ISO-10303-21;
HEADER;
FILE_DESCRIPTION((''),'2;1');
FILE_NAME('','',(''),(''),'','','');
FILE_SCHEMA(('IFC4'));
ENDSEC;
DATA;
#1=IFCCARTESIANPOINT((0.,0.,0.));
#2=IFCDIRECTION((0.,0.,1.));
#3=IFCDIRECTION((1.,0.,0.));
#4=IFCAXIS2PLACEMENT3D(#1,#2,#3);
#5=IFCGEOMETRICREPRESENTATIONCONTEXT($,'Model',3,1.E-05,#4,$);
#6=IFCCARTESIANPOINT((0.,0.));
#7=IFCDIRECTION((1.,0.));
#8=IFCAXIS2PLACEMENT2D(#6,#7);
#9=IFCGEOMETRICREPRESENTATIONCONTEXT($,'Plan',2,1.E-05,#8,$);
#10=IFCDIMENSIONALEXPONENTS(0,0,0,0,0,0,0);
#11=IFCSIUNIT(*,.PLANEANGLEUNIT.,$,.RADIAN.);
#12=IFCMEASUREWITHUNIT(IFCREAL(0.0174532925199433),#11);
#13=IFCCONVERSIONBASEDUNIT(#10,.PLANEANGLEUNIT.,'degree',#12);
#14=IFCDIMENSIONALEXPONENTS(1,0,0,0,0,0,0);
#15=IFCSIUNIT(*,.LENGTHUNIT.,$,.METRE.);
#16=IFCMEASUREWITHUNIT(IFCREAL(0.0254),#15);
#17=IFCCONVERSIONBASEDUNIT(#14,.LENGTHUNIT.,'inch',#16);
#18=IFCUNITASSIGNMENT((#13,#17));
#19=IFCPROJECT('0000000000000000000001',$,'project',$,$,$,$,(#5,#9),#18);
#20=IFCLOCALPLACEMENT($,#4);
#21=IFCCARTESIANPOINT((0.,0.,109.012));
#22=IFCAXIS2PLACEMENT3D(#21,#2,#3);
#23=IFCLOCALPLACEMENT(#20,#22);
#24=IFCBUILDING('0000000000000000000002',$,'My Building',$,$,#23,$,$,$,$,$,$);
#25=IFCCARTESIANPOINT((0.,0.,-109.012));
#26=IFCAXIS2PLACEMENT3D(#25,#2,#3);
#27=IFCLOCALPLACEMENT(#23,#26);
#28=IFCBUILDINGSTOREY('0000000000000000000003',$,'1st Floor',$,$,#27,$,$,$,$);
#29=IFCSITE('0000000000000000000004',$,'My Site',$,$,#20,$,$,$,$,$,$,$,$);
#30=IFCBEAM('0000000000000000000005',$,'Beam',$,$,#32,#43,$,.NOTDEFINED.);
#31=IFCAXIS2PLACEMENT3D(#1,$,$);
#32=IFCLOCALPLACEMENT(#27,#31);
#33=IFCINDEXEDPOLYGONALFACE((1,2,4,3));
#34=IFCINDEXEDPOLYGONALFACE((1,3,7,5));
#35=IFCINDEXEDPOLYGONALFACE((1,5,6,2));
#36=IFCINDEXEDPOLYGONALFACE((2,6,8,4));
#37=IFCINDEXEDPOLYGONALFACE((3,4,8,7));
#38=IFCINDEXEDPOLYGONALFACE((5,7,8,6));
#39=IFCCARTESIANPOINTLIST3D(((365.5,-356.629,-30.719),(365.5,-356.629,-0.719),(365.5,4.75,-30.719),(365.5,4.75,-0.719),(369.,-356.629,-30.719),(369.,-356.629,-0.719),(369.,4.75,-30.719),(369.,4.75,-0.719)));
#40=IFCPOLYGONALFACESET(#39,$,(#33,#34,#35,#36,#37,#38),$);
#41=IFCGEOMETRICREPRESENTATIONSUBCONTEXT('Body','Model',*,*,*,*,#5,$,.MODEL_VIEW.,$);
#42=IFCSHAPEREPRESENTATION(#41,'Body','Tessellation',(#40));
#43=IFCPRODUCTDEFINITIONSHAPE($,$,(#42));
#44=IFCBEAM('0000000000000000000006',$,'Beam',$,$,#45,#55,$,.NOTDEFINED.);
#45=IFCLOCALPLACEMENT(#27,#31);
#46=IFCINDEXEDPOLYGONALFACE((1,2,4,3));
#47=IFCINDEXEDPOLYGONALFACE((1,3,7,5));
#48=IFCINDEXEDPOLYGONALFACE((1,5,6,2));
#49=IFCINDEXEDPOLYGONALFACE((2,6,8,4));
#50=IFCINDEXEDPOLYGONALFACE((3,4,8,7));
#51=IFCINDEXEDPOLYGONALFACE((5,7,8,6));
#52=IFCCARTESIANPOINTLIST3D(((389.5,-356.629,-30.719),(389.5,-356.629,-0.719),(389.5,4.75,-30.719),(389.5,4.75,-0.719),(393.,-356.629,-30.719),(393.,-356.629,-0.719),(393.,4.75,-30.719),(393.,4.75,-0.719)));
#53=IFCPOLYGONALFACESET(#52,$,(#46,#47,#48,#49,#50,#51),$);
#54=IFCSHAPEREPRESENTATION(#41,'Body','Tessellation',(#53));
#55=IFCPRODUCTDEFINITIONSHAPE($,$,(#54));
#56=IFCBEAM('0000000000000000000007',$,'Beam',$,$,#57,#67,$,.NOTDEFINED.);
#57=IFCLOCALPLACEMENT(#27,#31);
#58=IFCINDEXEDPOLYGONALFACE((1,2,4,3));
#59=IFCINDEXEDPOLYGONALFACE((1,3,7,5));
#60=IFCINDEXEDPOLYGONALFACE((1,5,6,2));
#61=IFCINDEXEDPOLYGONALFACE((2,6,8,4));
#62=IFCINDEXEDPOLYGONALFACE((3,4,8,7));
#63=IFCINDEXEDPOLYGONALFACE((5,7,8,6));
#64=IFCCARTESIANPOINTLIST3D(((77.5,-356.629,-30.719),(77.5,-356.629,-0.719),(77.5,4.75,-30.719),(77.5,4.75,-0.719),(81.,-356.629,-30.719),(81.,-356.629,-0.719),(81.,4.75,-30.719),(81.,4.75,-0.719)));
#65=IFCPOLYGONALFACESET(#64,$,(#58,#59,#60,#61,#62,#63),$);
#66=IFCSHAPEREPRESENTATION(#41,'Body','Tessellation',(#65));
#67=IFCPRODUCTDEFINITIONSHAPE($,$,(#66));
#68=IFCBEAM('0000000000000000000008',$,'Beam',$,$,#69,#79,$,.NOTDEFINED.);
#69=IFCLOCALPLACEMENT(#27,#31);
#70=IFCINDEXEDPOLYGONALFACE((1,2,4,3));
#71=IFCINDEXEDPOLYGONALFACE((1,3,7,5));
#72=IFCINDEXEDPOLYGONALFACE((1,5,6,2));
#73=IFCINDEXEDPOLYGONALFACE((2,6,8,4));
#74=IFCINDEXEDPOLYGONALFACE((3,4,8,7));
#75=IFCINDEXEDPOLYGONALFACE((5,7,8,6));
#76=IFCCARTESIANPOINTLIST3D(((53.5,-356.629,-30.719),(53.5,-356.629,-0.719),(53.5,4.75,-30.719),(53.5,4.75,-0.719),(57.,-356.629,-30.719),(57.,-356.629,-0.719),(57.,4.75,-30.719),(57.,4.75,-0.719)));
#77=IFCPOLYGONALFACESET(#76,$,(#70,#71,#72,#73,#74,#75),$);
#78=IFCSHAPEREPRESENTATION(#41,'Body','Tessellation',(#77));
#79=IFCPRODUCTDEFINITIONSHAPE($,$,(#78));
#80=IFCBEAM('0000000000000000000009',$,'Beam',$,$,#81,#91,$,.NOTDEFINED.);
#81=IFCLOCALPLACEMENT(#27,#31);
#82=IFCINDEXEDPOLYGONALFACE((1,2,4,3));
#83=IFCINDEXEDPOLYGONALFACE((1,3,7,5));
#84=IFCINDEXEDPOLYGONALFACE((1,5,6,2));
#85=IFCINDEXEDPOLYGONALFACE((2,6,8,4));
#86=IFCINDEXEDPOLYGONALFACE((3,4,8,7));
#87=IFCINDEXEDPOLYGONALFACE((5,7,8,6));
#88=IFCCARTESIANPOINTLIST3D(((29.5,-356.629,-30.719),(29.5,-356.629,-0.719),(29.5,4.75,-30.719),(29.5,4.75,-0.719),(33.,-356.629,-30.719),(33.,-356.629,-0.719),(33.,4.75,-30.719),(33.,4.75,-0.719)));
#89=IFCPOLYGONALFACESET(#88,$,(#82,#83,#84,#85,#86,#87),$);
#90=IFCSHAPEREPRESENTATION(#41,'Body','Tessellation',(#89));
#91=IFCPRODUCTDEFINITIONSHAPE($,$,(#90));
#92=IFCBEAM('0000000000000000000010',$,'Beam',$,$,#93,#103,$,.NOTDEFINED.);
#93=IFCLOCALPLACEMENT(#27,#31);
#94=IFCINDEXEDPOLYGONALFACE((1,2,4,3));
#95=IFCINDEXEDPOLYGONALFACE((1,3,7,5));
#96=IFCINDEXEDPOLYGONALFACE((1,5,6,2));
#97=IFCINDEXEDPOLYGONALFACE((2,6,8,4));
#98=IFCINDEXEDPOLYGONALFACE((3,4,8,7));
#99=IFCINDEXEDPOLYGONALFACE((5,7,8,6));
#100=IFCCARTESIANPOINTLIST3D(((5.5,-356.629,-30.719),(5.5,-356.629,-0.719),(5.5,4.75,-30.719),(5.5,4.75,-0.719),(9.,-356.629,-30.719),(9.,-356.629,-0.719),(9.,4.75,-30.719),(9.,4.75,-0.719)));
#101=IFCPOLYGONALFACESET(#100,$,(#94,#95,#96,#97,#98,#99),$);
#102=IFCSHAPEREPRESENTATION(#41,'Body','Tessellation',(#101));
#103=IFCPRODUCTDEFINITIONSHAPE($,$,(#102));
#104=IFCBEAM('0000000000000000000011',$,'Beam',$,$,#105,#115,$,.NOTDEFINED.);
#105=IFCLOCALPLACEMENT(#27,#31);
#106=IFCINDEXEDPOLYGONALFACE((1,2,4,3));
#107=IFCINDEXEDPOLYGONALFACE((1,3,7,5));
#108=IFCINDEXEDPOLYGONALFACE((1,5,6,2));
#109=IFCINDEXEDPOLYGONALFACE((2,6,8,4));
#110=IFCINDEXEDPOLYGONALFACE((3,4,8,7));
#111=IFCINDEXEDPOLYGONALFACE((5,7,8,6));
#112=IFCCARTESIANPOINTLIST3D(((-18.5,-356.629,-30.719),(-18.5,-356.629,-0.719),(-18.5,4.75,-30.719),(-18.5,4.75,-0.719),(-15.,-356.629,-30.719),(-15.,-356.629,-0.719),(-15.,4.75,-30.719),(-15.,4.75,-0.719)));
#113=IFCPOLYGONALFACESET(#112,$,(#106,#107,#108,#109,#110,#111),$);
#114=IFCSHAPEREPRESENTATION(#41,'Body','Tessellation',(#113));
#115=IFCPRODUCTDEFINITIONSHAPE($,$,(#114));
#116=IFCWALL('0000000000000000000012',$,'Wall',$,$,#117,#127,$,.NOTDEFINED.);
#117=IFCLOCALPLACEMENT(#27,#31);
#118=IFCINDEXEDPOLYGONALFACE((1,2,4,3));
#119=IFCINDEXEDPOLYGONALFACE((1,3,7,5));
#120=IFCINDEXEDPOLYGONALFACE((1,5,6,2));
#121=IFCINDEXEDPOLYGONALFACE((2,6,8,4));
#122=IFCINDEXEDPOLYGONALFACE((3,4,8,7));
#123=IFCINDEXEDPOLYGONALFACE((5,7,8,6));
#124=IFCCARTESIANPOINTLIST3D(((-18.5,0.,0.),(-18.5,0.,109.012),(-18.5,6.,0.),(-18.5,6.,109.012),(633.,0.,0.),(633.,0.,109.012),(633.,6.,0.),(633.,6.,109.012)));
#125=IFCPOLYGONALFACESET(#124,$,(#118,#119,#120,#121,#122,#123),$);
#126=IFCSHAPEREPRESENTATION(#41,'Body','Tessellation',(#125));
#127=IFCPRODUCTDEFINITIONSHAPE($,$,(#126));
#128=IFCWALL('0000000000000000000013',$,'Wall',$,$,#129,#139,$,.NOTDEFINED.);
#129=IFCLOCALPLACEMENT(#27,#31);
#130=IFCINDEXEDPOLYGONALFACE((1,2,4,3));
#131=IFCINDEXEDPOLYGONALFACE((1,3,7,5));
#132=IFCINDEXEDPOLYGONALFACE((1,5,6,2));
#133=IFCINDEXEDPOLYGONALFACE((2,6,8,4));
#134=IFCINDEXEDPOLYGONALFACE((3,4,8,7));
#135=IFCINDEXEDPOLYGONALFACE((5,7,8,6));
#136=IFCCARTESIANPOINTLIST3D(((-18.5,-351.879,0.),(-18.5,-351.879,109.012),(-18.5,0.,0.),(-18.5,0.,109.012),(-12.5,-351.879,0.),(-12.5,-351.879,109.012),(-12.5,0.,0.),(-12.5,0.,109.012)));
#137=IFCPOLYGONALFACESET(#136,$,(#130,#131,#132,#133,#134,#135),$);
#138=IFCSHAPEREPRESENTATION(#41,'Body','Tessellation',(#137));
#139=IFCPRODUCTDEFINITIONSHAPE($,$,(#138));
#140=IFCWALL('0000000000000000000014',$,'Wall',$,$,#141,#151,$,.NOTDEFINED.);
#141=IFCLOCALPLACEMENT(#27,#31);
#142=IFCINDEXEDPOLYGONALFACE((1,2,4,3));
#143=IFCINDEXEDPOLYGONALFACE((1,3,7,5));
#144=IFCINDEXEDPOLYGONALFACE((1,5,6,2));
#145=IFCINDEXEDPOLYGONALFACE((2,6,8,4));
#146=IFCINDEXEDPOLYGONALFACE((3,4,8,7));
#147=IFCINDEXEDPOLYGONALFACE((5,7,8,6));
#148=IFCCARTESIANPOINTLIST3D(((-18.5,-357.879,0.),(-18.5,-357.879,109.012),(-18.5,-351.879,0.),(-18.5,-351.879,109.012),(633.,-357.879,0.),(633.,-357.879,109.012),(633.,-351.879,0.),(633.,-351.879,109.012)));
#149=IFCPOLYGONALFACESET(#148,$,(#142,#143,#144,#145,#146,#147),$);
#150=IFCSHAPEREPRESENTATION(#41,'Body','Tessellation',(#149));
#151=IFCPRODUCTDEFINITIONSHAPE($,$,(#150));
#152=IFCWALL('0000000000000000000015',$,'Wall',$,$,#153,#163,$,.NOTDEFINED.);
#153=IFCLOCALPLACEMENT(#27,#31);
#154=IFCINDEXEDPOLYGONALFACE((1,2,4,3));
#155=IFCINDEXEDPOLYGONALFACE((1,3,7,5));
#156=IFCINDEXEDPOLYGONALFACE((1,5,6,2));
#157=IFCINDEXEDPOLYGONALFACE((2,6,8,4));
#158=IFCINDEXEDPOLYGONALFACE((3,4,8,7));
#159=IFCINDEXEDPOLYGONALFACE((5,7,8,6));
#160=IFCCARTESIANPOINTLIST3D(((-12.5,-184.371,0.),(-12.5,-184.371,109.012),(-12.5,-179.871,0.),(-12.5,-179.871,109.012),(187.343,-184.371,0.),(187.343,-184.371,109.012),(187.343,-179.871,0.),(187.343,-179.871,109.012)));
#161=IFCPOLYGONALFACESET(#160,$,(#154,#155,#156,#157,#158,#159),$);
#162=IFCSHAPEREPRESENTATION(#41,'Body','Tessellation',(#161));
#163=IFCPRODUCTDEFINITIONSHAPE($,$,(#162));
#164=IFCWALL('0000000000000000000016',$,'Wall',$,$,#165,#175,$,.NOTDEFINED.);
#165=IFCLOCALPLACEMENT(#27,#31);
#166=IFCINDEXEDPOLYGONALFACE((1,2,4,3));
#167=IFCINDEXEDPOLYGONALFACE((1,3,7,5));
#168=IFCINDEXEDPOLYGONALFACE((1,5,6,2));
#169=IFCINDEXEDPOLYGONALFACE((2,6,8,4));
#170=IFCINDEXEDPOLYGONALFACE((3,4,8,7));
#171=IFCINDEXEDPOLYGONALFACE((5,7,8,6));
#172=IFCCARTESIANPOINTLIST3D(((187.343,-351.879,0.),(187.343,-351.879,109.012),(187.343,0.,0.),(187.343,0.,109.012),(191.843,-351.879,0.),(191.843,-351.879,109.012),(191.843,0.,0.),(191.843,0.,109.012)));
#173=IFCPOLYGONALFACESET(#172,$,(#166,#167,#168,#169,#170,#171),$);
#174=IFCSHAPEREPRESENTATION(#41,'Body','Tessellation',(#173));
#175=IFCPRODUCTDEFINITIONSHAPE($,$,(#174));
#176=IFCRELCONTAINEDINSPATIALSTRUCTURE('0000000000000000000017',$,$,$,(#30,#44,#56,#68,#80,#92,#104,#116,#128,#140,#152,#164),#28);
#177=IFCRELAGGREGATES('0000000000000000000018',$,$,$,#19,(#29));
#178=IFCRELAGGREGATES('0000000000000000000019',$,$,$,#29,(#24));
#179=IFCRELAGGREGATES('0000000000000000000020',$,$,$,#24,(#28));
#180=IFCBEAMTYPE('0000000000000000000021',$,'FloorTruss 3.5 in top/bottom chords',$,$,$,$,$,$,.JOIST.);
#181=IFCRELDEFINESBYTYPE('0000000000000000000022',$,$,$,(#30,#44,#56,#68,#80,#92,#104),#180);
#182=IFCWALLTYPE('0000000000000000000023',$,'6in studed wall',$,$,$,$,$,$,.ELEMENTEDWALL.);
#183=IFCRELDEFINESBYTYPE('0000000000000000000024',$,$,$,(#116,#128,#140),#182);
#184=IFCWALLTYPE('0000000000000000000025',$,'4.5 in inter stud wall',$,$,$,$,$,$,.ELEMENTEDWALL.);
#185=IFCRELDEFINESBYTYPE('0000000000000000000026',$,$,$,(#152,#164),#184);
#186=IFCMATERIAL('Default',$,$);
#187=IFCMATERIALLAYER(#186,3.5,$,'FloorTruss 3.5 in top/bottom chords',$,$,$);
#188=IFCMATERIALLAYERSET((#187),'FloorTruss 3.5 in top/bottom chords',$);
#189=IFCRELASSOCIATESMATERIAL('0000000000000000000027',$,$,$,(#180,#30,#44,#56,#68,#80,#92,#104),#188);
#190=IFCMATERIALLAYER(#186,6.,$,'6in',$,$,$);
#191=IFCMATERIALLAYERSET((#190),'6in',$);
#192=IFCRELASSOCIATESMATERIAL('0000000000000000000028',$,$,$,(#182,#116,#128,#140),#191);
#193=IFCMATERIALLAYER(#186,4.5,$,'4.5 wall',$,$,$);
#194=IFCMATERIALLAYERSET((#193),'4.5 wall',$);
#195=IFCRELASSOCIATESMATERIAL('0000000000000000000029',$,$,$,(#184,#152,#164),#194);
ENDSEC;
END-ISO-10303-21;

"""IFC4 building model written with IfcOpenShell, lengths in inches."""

from ifc_helpers import new_model, entity, si_unit, converted_unit, frame, origin_with_axes, origin_2d_with_axis, place, context, subcontext, project, spatial, indexed_curve, outline, extrude, material, layer, layer_set, layer_usage, type_object, element, save


model = new_model("IFC4")

# Units and contexts
model_context = context("Model", 3, precision=1e-05, world=origin_with_axes())
plan_context = context("Plan", 2, precision=1e-05, world=origin_2d_with_axis())
body_context = subcontext(model_context, "Body", "Model", "MODEL_VIEW")
ifc_project = project(units=[converted_unit("PLANEANGLEUNIT", "degree", entity("IfcReal", 0.0174532925199433), si_unit("PLANEANGLEUNIT", "RADIAN"), dimensions=[0, 0, 0, 0, 0, 0, 0]), converted_unit("LENGTHUNIT", "inch", entity("IfcReal", 0.0254), si_unit("LENGTHUNIT", "METRE"), dimensions=[1, 0, 0, 0, 0, 0, 0])], contexts=[model_context, plan_context])

# Site, building, storey
site_placement = place(None, origin_with_axes())
site = spatial("IfcSite", under=ifc_project, at=site_placement, Name="My Site")
building_placement = place(site_placement, frame((0.0, 0.0, 109.012), z_axis=(0.0, 0.0, 1.0), x_axis=(1.0, 0.0, 0.0)))
building = spatial("IfcBuilding", under=site, at=building_placement, Name="My Building")
storey_placement = place(building_placement, frame((0.0, 0.0, -109.012), z_axis=(0.0, 0.0, 1.0), x_axis=(1.0, 0.0, 0.0)))
storey = spatial("IfcBuildingStorey", under=building, at=storey_placement, Name="1st Floor")

# Beams
ifc_material = material(Name="Default")
ifc_layer_1 = layer(ifc_material, 3.5, Name="FloorTruss 3.5 in top/bottom chords")
ifc_layer_set_1 = layer_set([ifc_layer_1], Name="FloorTruss 3.5 in top/bottom chords")
beam_type_1 = type_object("IfcBeamType", Name="FloorTruss 3.5 in top/bottom chords", PredefinedType="JOIST", material=ifc_layer_set_1)
ifc_layer_usage_1 = layer_usage(ifc_layer_set_1, "AXIS2", "POSITIVE", 0.0)
beam_1_placement = place(storey_placement, frame((369.0, -356.629, -30.719), z_axis=(0.0, 0.0, 1.0), x_axis=(0.0, 1.0, 0.0)))
element("IfcBeam", 1, at=beam_1_placement, inside=storey, type_object=beam_type_1, material=ifc_layer_usage_1, Name="Beam", PredefinedType="NOTDEFINED", context=body_context, shape_type="SweptSolid", body=[
    extrude(outline(indexed_curve([(0.0, 0.0), (0.0, 3.5), (361.379, 3.5), (361.379, 0.0), (0.0, 0.0)], self_intersect=False)), origin_with_axes(), (0.0, 0.0, 1.0), 30.0),
])
ifc_layer_usage_2 = layer_usage(ifc_layer_set_1, "AXIS2", "POSITIVE", 0.0)
beam_2_placement = place(storey_placement, frame((393.0, -356.629, -30.719), z_axis=(0.0, 0.0, 1.0), x_axis=(0.0, 1.0, 0.0)))
element("IfcBeam", 2, at=beam_2_placement, inside=storey, type_object=beam_type_1, material=ifc_layer_usage_2, Name="Beam", PredefinedType="NOTDEFINED", context=body_context, shape_type="SweptSolid", body=[
    extrude(outline(indexed_curve([(0.0, 0.0), (0.0, 3.5), (361.379, 3.5), (361.379, 0.0), (0.0, 0.0)], self_intersect=False)), origin_with_axes(), (0.0, 0.0, 1.0), 30.0),
])
ifc_layer_usage_3 = layer_usage(ifc_layer_set_1, "AXIS2", "POSITIVE", 0.0)
beam_3_placement = place(storey_placement, frame((81.0, -356.629, -30.719), z_axis=(0.0, 0.0, 1.0), x_axis=(0.0, 1.0, 0.0)))
element("IfcBeam", 3, at=beam_3_placement, inside=storey, type_object=beam_type_1, material=ifc_layer_usage_3, Name="Beam", PredefinedType="NOTDEFINED", context=body_context, shape_type="SweptSolid", body=[
    extrude(outline(indexed_curve([(0.0, 0.0), (0.0, 3.5), (361.379, 3.5), (361.379, 0.0), (0.0, 0.0)], self_intersect=False)), origin_with_axes(), (0.0, 0.0, 1.0), 30.0),
])
ifc_layer_usage_4 = layer_usage(ifc_layer_set_1, "AXIS2", "POSITIVE", 0.0)
beam_4_placement = place(storey_placement, frame((57.0, -356.629, -30.719), z_axis=(0.0, 0.0, 1.0), x_axis=(0.0, 1.0, 0.0)))
element("IfcBeam", 4, at=beam_4_placement, inside=storey, type_object=beam_type_1, material=ifc_layer_usage_4, Name="Beam", PredefinedType="NOTDEFINED", context=body_context, shape_type="SweptSolid", body=[
    extrude(outline(indexed_curve([(0.0, 0.0), (0.0, 3.5), (361.379, 3.5), (361.379, 0.0), (0.0, 0.0)], self_intersect=False)), origin_with_axes(), (0.0, 0.0, 1.0), 30.0),
])
ifc_layer_usage_5 = layer_usage(ifc_layer_set_1, "AXIS2", "POSITIVE", 0.0)
beam_5_placement = place(storey_placement, frame((33.0, -356.629, -30.719), z_axis=(0.0, 0.0, 1.0), x_axis=(0.0, 1.0, 0.0)))
element("IfcBeam", 5, at=beam_5_placement, inside=storey, type_object=beam_type_1, material=ifc_layer_usage_5, Name="Beam", PredefinedType="NOTDEFINED", context=body_context, shape_type="SweptSolid", body=[
    extrude(outline(indexed_curve([(0.0, 0.0), (0.0, 3.5), (361.379, 3.5), (361.379, 0.0), (0.0, 0.0)], self_intersect=False)), origin_with_axes(), (0.0, 0.0, 1.0), 30.0),
])
ifc_layer_usage_6 = layer_usage(ifc_layer_set_1, "AXIS2", "POSITIVE", 0.0)
beam_6_placement = place(storey_placement, frame((9.0, -356.629, -30.719), z_axis=(0.0, 0.0, 1.0), x_axis=(0.0, 1.0, 0.0)))
element("IfcBeam", 6, at=beam_6_placement, inside=storey, type_object=beam_type_1, material=ifc_layer_usage_6, Name="Beam", PredefinedType="NOTDEFINED", context=body_context, shape_type="SweptSolid", body=[
    extrude(outline(indexed_curve([(0.0, 0.0), (0.0, 3.5), (361.379, 3.5), (361.379, 0.0), (0.0, 0.0)], self_intersect=False)), origin_with_axes(), (0.0, 0.0, 1.0), 30.0),
])
ifc_layer_usage_7 = layer_usage(ifc_layer_set_1, "AXIS2", "POSITIVE", 0.0)
beam_7_placement = place(storey_placement, frame((-15.0, -356.629, -30.719), z_axis=(0.0, 0.0, 1.0), x_axis=(0.0, 1.0, 0.0)))
element("IfcBeam", 7, at=beam_7_placement, inside=storey, type_object=beam_type_1, material=ifc_layer_usage_7, Name="Beam", PredefinedType="NOTDEFINED", context=body_context, shape_type="SweptSolid", body=[
    extrude(outline(indexed_curve([(0.0, 0.0), (0.0, 3.5), (361.379, 3.5), (361.379, 0.0), (0.0, 0.0)], self_intersect=False)), origin_with_axes(), (0.0, 0.0, 1.0), 30.0),
])

# Walls
ifc_layer_2 = layer(ifc_material, 6.0, Name="6in")
ifc_layer_set_2 = layer_set([ifc_layer_2], Name="6in")
ifc_layer_usage_8 = layer_usage(ifc_layer_set_2, "AXIS2", "POSITIVE", 0.0)
wall_type_1 = type_object("IfcWallType", Name="6in studed wall", PredefinedType="ELEMENTEDWALL", material=ifc_layer_set_2)
wall_1_placement = place(storey_placement, frame((-18.5, 0.0, 0.0), z_axis=(0.0, 0.0, 1.0), x_axis=(1.0, 0.0, 0.0)))
element("IfcWall", 8, at=wall_1_placement, inside=storey, type_object=wall_type_1, material=ifc_layer_usage_8, Name="Wall", PredefinedType="NOTDEFINED", context=body_context, shape_type="SweptSolid", body=[
    extrude(outline(indexed_curve([(0.0, 0.0), (0.0, 6.0), (651.5, 6.0), (651.5, 0.0), (0.0, 0.0)], self_intersect=False)), origin_with_axes(), (0.0, 0.0, 1.0), 109.012),
])
ifc_layer_usage_9 = layer_usage(ifc_layer_set_2, "AXIS2", "POSITIVE", 0.0)
wall_2_placement = place(storey_placement, frame((-18.5, 0.0, 0.0), z_axis=(0.0, 0.0, 1.0), x_axis=(0.0, -1.0, 0.0)))
element("IfcWall", 9, at=wall_2_placement, inside=storey, type_object=wall_type_1, material=ifc_layer_usage_9, Name="Wall", PredefinedType="NOTDEFINED", context=body_context, shape_type="SweptSolid", body=[
    extrude(outline(indexed_curve([(0.0, 0.0), (0.0, 6.0), (351.879, 6.0), (351.879, 0.0), (0.0, 0.0)], self_intersect=False)), origin_with_axes(), (0.0, 0.0, 1.0), 109.012),
])
ifc_layer_usage_10 = layer_usage(ifc_layer_set_2, "AXIS2", "POSITIVE", 0.0)
wall_3_placement = place(storey_placement, frame((-18.5, -357.879, 0.0), z_axis=(0.0, 0.0, 1.0), x_axis=(1.0, 0.0, 0.0)))
element("IfcWall", 10, at=wall_3_placement, inside=storey, type_object=wall_type_1, material=ifc_layer_usage_10, Name="Wall", PredefinedType="NOTDEFINED", context=body_context, shape_type="SweptSolid", body=[
    extrude(outline(indexed_curve([(0.0, 0.0), (0.0, 6.0), (651.5, 6.0), (651.5, 0.0), (0.0, 0.0)], self_intersect=False)), origin_with_axes(), (0.0, 0.0, 1.0), 109.012),
])
ifc_layer_3 = layer(ifc_material, 4.5, Name="4.5 wall")
ifc_layer_set_3 = layer_set([ifc_layer_3], Name="4.5 wall")
ifc_layer_usage_11 = layer_usage(ifc_layer_set_3, "AXIS2", "POSITIVE", 0.0)
wall_type_2 = type_object("IfcWallType", Name="4.5 in inter stud wall", PredefinedType="ELEMENTEDWALL", material=ifc_layer_set_3)
wall_4_placement = place(storey_placement, frame((-12.5, -184.371, 0.0), z_axis=(0.0, 0.0, 1.0), x_axis=(1.0, 0.0, 0.0)))
element("IfcWall", 11, at=wall_4_placement, inside=storey, type_object=wall_type_2, material=ifc_layer_usage_11, Name="Wall", PredefinedType="NOTDEFINED", context=body_context, shape_type="SweptSolid", body=[
    extrude(outline(indexed_curve([(0.0, 0.0), (0.0, 4.5), (199.843, 4.5), (199.843, 0.0), (0.0, 0.0)], self_intersect=False)), origin_with_axes(), (0.0, 0.0, 1.0), 109.012),
])
ifc_layer_usage_12 = layer_usage(ifc_layer_set_3, "AXIS2", "POSITIVE", 0.0)
wall_5_placement = place(storey_placement, frame((187.343, 0.0, 0.0), z_axis=(0.0, 0.0, 1.0), x_axis=(0.0, -1.0, 0.0)))
element("IfcWall", 12, at=wall_5_placement, inside=storey, type_object=wall_type_2, material=ifc_layer_usage_12, Name="Wall", PredefinedType="NOTDEFINED", context=body_context, shape_type="SweptSolid", body=[
    extrude(outline(indexed_curve([(0.0, 0.0), (0.0, 4.5), (351.879, 4.5), (351.879, 0.0), (0.0, 0.0)], self_intersect=False)), origin_with_axes(), (0.0, 0.0, 1.0), 109.012),
])

save(model, "model.ifc")
